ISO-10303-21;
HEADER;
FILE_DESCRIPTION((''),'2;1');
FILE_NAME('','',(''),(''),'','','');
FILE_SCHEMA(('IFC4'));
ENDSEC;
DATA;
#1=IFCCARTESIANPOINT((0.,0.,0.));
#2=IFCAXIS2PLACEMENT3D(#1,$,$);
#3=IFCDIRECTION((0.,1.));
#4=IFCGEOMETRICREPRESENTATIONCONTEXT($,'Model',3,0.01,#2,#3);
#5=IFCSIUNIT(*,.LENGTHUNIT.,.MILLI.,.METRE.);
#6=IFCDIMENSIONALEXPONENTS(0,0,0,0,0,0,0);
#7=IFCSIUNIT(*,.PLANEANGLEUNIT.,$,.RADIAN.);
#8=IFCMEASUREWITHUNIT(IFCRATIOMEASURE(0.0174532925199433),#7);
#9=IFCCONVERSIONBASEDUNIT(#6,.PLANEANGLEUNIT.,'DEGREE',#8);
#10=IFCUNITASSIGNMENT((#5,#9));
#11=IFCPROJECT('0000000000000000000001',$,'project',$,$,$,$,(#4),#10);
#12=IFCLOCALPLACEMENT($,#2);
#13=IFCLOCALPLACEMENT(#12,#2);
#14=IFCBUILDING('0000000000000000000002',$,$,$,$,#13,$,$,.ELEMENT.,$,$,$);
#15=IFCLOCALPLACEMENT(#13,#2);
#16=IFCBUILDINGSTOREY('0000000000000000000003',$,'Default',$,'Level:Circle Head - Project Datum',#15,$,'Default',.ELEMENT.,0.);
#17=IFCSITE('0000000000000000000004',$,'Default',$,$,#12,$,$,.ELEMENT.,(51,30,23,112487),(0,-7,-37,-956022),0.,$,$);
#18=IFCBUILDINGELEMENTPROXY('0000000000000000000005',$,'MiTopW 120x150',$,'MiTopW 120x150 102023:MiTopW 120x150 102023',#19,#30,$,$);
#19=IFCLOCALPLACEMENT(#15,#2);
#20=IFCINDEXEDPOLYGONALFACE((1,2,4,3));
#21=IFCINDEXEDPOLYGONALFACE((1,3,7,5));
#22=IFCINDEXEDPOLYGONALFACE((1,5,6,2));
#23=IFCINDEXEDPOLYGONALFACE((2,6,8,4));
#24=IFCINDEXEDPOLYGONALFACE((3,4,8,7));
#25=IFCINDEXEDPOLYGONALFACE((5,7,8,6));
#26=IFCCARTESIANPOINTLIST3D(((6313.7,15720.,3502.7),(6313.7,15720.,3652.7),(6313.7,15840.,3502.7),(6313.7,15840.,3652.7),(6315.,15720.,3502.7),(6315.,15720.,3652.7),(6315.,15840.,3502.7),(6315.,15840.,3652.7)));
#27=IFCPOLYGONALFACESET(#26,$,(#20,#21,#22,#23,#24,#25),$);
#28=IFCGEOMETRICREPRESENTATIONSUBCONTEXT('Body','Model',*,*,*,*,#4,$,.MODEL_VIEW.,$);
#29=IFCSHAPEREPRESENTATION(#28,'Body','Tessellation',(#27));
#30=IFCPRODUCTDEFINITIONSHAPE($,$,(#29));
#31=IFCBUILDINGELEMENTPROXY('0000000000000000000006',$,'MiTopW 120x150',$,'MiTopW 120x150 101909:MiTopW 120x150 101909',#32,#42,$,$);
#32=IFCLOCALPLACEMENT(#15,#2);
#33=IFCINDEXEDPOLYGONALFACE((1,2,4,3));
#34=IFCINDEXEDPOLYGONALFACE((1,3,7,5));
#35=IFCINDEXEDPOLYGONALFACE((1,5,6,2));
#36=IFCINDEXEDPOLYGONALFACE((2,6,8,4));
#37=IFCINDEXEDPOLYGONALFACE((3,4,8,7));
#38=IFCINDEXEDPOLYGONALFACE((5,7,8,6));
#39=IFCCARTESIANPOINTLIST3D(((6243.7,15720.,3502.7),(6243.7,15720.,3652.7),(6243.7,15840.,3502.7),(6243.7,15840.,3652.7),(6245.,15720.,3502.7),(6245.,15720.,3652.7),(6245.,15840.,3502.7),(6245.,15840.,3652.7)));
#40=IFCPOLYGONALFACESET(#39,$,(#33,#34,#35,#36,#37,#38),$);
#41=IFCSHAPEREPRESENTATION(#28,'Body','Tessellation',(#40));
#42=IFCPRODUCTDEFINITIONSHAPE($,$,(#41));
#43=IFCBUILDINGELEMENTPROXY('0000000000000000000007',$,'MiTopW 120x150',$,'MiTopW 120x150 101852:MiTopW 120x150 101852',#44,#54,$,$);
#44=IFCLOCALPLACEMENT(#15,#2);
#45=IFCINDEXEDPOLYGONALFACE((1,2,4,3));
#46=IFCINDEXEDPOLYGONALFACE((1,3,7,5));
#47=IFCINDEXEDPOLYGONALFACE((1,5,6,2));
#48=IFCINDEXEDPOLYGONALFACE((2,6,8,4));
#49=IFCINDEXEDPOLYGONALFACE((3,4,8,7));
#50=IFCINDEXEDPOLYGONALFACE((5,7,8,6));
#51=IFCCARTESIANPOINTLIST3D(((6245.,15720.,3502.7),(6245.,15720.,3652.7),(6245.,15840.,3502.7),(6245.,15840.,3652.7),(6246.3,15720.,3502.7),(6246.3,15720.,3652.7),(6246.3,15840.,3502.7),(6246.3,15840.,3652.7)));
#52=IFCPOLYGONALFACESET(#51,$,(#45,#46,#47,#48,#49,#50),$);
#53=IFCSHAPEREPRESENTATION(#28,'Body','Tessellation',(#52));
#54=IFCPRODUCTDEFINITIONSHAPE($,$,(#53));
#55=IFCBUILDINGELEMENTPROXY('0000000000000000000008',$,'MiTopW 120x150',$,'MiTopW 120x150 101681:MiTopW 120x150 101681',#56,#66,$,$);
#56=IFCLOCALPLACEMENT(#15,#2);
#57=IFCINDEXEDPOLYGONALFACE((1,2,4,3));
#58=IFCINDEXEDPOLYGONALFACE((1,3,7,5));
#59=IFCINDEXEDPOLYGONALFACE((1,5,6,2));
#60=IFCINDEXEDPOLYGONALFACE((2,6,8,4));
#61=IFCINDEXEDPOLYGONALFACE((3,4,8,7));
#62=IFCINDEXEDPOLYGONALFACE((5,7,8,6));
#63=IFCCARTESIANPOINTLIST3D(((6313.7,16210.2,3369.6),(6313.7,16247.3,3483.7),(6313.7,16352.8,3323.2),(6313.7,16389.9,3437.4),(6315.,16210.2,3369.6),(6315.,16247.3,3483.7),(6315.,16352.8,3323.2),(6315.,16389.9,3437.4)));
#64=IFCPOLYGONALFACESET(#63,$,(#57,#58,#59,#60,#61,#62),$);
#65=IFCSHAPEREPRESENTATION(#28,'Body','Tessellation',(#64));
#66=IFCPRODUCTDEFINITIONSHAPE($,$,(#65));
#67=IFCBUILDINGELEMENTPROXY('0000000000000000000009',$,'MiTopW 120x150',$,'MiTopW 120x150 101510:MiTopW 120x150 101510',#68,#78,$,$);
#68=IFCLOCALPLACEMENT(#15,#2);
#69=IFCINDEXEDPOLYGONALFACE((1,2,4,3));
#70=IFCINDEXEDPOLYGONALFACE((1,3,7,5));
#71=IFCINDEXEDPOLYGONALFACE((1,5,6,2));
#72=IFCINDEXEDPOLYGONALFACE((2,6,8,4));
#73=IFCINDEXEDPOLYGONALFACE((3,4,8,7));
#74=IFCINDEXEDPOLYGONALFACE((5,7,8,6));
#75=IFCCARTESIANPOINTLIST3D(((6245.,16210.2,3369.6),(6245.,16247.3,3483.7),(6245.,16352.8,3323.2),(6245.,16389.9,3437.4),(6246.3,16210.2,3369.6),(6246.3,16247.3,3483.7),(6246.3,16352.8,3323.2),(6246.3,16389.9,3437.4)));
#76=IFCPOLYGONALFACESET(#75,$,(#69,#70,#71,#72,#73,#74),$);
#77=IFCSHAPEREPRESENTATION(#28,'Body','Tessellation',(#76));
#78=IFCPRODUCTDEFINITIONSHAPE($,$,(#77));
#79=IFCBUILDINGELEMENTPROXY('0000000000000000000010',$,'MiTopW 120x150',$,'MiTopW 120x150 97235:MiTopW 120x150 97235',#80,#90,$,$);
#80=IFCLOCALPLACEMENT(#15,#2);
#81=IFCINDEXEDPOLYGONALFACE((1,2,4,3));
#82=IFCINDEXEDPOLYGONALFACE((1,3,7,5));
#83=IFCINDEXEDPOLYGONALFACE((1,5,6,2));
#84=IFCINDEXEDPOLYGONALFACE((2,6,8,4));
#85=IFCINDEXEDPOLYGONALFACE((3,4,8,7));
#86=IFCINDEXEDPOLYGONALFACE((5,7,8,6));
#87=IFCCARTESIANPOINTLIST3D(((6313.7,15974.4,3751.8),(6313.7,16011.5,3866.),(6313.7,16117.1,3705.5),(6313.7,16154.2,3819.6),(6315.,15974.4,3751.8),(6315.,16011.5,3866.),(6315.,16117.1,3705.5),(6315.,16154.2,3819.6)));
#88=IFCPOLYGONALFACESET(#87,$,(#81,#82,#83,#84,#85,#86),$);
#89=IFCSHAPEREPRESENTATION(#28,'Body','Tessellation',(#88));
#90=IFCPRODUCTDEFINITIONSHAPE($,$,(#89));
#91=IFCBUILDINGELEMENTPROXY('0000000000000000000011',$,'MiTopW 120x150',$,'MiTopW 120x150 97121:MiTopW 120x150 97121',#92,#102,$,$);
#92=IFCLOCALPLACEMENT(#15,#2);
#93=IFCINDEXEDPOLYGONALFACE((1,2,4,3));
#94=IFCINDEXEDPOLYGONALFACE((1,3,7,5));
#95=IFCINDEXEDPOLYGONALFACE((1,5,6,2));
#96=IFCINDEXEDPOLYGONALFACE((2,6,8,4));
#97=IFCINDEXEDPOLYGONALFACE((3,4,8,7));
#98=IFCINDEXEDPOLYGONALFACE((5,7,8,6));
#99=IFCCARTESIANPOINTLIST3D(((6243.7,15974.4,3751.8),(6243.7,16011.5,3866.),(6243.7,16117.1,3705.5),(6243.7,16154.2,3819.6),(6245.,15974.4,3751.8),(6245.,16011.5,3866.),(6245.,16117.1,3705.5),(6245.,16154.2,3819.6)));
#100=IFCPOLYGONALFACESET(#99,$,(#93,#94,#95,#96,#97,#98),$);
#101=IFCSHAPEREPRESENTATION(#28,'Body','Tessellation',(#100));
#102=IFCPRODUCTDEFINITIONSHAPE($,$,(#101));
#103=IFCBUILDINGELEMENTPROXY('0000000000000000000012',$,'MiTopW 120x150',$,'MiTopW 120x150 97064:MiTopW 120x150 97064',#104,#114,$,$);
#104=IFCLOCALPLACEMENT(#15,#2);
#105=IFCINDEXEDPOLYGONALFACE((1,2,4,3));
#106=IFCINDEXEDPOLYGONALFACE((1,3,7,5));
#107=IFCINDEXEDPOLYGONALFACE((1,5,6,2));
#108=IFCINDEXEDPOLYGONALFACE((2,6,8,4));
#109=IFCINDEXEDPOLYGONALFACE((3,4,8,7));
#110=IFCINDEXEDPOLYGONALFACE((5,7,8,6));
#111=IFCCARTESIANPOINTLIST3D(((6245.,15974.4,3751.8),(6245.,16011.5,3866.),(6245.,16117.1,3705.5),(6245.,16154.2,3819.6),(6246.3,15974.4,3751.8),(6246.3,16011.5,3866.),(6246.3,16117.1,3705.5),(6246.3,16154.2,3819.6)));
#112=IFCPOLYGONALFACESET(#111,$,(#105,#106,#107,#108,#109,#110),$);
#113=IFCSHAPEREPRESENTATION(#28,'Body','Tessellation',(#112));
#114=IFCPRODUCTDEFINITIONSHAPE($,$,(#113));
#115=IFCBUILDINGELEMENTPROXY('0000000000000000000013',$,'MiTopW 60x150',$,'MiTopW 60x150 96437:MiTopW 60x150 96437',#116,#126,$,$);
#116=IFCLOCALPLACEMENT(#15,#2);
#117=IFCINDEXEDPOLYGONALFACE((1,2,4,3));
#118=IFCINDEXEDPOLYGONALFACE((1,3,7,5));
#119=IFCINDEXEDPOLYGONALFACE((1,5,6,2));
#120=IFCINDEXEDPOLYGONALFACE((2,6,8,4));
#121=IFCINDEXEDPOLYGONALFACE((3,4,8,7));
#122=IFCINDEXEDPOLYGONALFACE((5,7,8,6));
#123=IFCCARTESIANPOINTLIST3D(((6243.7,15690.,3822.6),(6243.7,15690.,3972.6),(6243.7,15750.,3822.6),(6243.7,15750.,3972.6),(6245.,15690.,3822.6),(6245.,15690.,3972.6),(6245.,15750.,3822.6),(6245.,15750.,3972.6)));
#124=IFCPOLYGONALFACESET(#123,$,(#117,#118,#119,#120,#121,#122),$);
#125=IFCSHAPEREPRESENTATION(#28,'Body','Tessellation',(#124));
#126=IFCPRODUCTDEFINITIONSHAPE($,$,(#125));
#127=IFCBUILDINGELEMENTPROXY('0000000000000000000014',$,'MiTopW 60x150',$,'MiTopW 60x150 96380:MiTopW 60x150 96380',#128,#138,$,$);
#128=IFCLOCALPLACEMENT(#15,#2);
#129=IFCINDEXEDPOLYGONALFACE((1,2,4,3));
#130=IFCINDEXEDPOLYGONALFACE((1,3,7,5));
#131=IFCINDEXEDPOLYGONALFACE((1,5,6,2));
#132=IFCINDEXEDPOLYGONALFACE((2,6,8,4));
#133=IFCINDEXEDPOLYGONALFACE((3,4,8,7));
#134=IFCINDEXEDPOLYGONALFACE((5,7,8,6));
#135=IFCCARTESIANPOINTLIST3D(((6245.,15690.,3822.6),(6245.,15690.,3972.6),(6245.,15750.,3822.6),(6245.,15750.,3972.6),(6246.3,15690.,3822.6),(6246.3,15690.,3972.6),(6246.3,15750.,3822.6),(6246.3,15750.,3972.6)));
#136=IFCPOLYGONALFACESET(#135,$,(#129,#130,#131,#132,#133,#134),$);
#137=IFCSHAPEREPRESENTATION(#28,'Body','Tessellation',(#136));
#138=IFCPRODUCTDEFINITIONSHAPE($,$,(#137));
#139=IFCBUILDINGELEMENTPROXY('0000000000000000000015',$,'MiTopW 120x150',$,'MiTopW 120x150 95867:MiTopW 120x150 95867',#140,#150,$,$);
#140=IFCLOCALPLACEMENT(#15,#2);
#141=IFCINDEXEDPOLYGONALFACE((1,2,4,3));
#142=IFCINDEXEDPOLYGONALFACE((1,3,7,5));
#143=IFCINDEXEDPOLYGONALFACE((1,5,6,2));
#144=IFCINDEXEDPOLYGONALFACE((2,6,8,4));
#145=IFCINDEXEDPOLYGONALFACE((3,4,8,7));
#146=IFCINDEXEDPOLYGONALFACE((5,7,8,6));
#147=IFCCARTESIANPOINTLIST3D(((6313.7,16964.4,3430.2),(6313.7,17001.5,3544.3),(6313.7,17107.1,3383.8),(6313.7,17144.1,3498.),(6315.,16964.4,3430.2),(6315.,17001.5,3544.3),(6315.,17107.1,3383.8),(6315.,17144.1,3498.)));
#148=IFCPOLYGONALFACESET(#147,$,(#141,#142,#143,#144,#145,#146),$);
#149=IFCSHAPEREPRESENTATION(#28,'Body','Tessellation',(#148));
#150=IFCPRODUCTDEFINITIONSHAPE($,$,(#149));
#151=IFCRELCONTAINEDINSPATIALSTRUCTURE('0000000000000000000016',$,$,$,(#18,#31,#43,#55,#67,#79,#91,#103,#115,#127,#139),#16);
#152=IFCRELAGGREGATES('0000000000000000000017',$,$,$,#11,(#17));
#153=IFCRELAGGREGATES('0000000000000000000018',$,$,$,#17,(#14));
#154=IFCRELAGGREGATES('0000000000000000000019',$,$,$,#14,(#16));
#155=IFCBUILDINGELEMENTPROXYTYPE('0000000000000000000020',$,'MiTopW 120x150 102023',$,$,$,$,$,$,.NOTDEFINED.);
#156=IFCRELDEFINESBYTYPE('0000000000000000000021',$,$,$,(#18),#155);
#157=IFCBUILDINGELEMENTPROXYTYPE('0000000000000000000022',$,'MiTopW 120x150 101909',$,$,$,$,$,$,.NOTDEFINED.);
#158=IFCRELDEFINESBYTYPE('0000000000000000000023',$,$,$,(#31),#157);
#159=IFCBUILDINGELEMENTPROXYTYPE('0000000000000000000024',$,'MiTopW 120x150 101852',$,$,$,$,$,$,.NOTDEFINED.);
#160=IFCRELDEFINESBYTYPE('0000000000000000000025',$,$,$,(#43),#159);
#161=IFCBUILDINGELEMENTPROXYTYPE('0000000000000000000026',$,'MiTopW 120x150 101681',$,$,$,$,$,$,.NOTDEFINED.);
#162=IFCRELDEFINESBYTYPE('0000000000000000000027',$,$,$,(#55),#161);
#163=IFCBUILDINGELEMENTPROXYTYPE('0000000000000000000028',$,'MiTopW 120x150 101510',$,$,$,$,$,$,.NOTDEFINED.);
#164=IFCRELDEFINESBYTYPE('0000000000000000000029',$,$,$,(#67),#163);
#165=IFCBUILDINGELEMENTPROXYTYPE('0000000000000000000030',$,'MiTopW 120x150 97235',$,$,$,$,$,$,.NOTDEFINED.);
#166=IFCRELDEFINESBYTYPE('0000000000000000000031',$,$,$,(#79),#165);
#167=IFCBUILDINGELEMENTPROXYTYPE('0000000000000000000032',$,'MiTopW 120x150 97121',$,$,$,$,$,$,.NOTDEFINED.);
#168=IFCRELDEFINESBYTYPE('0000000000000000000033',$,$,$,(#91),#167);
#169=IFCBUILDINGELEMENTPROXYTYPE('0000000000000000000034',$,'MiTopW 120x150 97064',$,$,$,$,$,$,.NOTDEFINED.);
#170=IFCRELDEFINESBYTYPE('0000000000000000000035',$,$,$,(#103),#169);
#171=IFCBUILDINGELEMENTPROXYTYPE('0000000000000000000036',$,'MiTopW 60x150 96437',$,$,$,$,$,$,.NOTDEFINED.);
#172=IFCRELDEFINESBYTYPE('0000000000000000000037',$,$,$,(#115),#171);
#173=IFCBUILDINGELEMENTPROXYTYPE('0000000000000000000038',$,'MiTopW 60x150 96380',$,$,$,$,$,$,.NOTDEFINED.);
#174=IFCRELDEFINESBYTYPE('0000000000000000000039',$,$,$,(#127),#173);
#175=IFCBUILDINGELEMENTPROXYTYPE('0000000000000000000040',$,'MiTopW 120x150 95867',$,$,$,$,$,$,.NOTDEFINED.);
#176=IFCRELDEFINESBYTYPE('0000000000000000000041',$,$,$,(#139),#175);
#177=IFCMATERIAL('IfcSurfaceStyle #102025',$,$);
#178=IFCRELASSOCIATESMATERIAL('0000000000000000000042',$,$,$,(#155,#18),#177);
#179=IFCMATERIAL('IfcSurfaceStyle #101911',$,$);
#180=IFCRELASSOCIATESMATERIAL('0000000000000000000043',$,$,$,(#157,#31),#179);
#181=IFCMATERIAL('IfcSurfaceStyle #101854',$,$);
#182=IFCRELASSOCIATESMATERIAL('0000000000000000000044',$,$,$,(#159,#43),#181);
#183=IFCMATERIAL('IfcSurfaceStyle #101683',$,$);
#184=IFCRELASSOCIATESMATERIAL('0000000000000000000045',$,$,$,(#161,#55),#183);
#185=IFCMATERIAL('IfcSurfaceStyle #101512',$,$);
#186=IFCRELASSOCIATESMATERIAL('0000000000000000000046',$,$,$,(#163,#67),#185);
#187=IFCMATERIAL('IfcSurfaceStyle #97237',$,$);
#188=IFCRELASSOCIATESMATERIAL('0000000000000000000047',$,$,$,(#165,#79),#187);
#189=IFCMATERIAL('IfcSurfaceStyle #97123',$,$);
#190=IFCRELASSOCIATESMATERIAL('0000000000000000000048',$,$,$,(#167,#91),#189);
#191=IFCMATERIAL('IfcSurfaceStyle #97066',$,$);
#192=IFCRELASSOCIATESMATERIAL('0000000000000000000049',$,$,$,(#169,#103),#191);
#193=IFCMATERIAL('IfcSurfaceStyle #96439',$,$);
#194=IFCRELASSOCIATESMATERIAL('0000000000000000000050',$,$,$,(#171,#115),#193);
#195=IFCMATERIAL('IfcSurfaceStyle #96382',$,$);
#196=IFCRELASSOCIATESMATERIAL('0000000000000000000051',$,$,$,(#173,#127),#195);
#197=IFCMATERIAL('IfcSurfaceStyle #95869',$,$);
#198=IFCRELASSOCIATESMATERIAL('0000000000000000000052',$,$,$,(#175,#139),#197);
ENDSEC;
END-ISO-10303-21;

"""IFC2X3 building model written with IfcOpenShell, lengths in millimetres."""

from ifc_helpers import new_model, entity, si_unit, converted_unit, direction, frame, origin, origin_2d_with_axis, place, context, subcontext, project, spatial, polyline, rectangle, outline, extrude, source, transform, mapped, material, type_object, type_shapes, element, save


model = new_model("IFC2X3")

# Units and contexts
model_context = context("Model", 3, precision=0.01, world=origin(), true_north=direction((0.0, 1.0)))
body_context = subcontext(model_context, "Body", "Model", "MODEL_VIEW")
ifc_project = project(units=[si_unit("LENGTHUNIT", "METRE", prefix="MILLI"), converted_unit("PLANEANGLEUNIT", "DEGREE", entity("IfcRatioMeasure", 0.0174532925199433), si_unit("PLANEANGLEUNIT", "RADIAN"), dimensions=[0, 0, 0, 0, 0, 0, 0])], contexts=[model_context])

# Site, building, storey
site_placement = place(None, origin())
site = spatial("IfcSite", under=ifc_project, at=site_placement, Name="Default", CompositionType="ELEMENT", RefLatitude=(51, 30, 23, 112487), RefLongitude=(0, -7, -37, -956022), RefElevation=0.0)
building_placement = place(site_placement, origin())
building = spatial("IfcBuilding", under=site, at=building_placement, CompositionType="ELEMENT")
storey_placement = place(building_placement, origin())
storey = spatial("IfcBuildingStorey", under=building, at=storey_placement, Name="Default", ObjectType="Level:Circle Head - Project Datum", LongName="Default", CompositionType="ELEMENT", Elevation=0.0)

# Building element proxies
ifc_material_1 = material(Name="IfcSurfaceStyle #102025")
building_element_proxy_type_1 = type_object("IfcBuildingElementProxyType", Name="MiTopW 120x150 102023", PredefinedType="NOTDEFINED", material=ifc_material_1)
shared_shape_1 = source(origin(), body_context, "Body", "SweptSolid", [
    extrude(rectangle(XDim=150.0, YDim=120.0, at=origin_2d_with_axis()), frame((75.0, 60.0, 0.0), z_axis=(0.0, 0.0, 1.0), x_axis=(-1.0, 0.0, 0.0)), (0.0, 0.0, 1.0), 1.3),
])
type_shapes(building_element_proxy_type_1, [shared_shape_1])
proxy_1_placement = place(building_placement, frame((6315.0, 15840.0, 3652.7), z_axis=(-1.0, 0.0, 0.0), x_axis=(0.0, 0.0, -1.0)))
element("IfcBuildingElementProxy", 1, at=proxy_1_placement, inside=storey, type_object=building_element_proxy_type_1, material=ifc_material_1, Name="MiTopW 120x150", ObjectType="MiTopW 120x150 102023:MiTopW 120x150 102023", context=body_context, shape_type="MappedRepresentation", body=[
    mapped(shared_shape_1, transform((0.0, 0.0, 0.0), scale=1.0)),
])
ifc_material_2 = material(Name="IfcSurfaceStyle #101911")
building_element_proxy_type_2 = type_object("IfcBuildingElementProxyType", Name="MiTopW 120x150 101909", PredefinedType="NOTDEFINED", material=ifc_material_2)
shared_shape_2 = source(origin(), body_context, "Body", "SweptSolid", [
    extrude(rectangle(XDim=150.0, YDim=120.0, at=origin_2d_with_axis()), frame((75.0, 60.0, 0.0), z_axis=(0.0, 0.0, 1.0), x_axis=(-1.0, 0.0, 0.0)), (0.0, 0.0, 1.0), 1.3),
])
type_shapes(building_element_proxy_type_2, [shared_shape_2])
proxy_2_placement = place(building_placement, frame((6245.0, 15840.0, 3652.7), z_axis=(-1.0, 0.0, 0.0), x_axis=(0.0, 0.0, -1.0)))
element("IfcBuildingElementProxy", 2, at=proxy_2_placement, inside=storey, type_object=building_element_proxy_type_2, material=ifc_material_2, Name="MiTopW 120x150", ObjectType="MiTopW 120x150 101909:MiTopW 120x150 101909", context=body_context, shape_type="MappedRepresentation", body=[
    mapped(shared_shape_2, transform((0.0, 0.0, 0.0), scale=1.0)),
])
ifc_material_3 = material(Name="IfcSurfaceStyle #101854")
building_element_proxy_type_3 = type_object("IfcBuildingElementProxyType", Name="MiTopW 120x150 101852", PredefinedType="NOTDEFINED", material=ifc_material_3)
shared_shape_3 = source(origin(), body_context, "Body", "SweptSolid", [
    extrude(rectangle(XDim=150.0, YDim=120.0, at=origin_2d_with_axis()), frame((75.0, 60.0, 0.0), z_axis=(0.0, 0.0, 1.0), x_axis=(-1.0, 0.0, 0.0)), (0.0, 0.0, 1.0), 1.3),
])
type_shapes(building_element_proxy_type_3, [shared_shape_3])
proxy_3_placement = place(building_placement, frame((6246.3, 15840.0, 3652.7), z_axis=(-1.0, 0.0, 0.0), x_axis=(0.0, 0.0, -1.0)))
element("IfcBuildingElementProxy", 3, at=proxy_3_placement, inside=storey, type_object=building_element_proxy_type_3, material=ifc_material_3, Name="MiTopW 120x150", ObjectType="MiTopW 120x150 101852:MiTopW 120x150 101852", context=body_context, shape_type="MappedRepresentation", body=[
    mapped(shared_shape_3, transform((0.0, 0.0, 0.0), scale=1.0)),
])
ifc_material_4 = material(Name="IfcSurfaceStyle #101683")
building_element_proxy_type_4 = type_object("IfcBuildingElementProxyType", Name="MiTopW 120x150 101681", PredefinedType="NOTDEFINED", material=ifc_material_4)
shared_shape_4 = source(origin(), body_context, "Body", "SweptSolid", [
    extrude(outline(polyline([(-75.0, -60.0), (75.0, -60.0), (75.0, 60.0), (-75.0, 60.0), (-75.0, -60.0)])), frame((75.0, 60.0, 0.0), z_axis=(0.0, 0.0, 1.0), x_axis=(-1.0, 0.0, 0.0)), (0.0, 0.0, 1.0), 1.3),
])
type_shapes(building_element_proxy_type_4, [shared_shape_4])
proxy_4_placement = place(building_placement, frame((6315.0, 16352.8, 3323.2), z_axis=(-1.0, 0.0, 0.0), x_axis=(0.0, -0.951057, 0.309017)))
element("IfcBuildingElementProxy", 4, at=proxy_4_placement, inside=storey, type_object=building_element_proxy_type_4, material=ifc_material_4, Name="MiTopW 120x150", ObjectType="MiTopW 120x150 101681:MiTopW 120x150 101681", context=body_context, shape_type="MappedRepresentation", body=[
    mapped(shared_shape_4, transform((0.0, 0.0, 0.0), scale=1.0)),
])
ifc_material_5 = material(Name="IfcSurfaceStyle #101512")
building_element_proxy_type_5 = type_object("IfcBuildingElementProxyType", Name="MiTopW 120x150 101510", PredefinedType="NOTDEFINED", material=ifc_material_5)
shared_shape_5 = source(origin(), body_context, "Body", "SweptSolid", [
    extrude(outline(polyline([(-75.0, -60.0), (75.0, -60.0), (75.0, 60.0), (-75.0, 60.0), (-75.0, -60.0)])), frame((75.0, 60.0, 0.0), z_axis=(0.0, 0.0, 1.0), x_axis=(-1.0, 0.0, 0.0)), (0.0, 0.0, 1.0), 1.3),
])
type_shapes(building_element_proxy_type_5, [shared_shape_5])
proxy_5_placement = place(building_placement, frame((6246.3, 16352.8, 3323.2), z_axis=(-1.0, 0.0, 0.0), x_axis=(0.0, -0.951057, 0.309017)))
element("IfcBuildingElementProxy", 5, at=proxy_5_placement, inside=storey, type_object=building_element_proxy_type_5, material=ifc_material_5, Name="MiTopW 120x150", ObjectType="MiTopW 120x150 101510:MiTopW 120x150 101510", context=body_context, shape_type="MappedRepresentation", body=[
    mapped(shared_shape_5, transform((0.0, 0.0, 0.0), scale=1.0)),
])
ifc_material_6 = material(Name="IfcSurfaceStyle #97237")
building_element_proxy_type_6 = type_object("IfcBuildingElementProxyType", Name="MiTopW 120x150 97235", PredefinedType="NOTDEFINED", material=ifc_material_6)
shared_shape_6 = source(origin(), body_context, "Body", "SweptSolid", [
    extrude(outline(polyline([(-75.0, -60.0), (75.0, -60.0), (75.0, 60.0), (-75.0, 60.0), (-75.0, -60.0)])), frame((75.0, 60.0, 0.0), z_axis=(0.0, 0.0, 1.0), x_axis=(-1.0, 0.0, 0.0)), (0.0, 0.0, 1.0), 1.3),
])
type_shapes(building_element_proxy_type_6, [shared_shape_6])
proxy_6_placement = place(building_placement, frame((6315.0, 16117.1, 3705.5), z_axis=(-1.0, 0.0, 0.0), x_axis=(0.0, -0.951057, 0.309017)))
element("IfcBuildingElementProxy", 6, at=proxy_6_placement, inside=storey, type_object=building_element_proxy_type_6, material=ifc_material_6, Name="MiTopW 120x150", ObjectType="MiTopW 120x150 97235:MiTopW 120x150 97235", context=body_context, shape_type="MappedRepresentation", body=[
    mapped(shared_shape_6, transform((0.0, 0.0, 0.0), scale=1.0)),
])
ifc_material_7 = material(Name="IfcSurfaceStyle #97123")
building_element_proxy_type_7 = type_object("IfcBuildingElementProxyType", Name="MiTopW 120x150 97121", PredefinedType="NOTDEFINED", material=ifc_material_7)
shared_shape_7 = source(origin(), body_context, "Body", "SweptSolid", [
    extrude(outline(polyline([(-75.0, -60.0), (75.0, -60.0), (75.0, 60.0), (-75.0, 60.0), (-75.0, -60.0)])), frame((75.0, 60.0, 0.0), z_axis=(0.0, 0.0, 1.0), x_axis=(-1.0, 0.0, 0.0)), (0.0, 0.0, 1.0), 1.3),
])
type_shapes(building_element_proxy_type_7, [shared_shape_7])
proxy_7_placement = place(building_placement, frame((6245.0, 16117.1, 3705.5), z_axis=(-1.0, 0.0, 0.0), x_axis=(0.0, -0.951057, 0.309017)))
element("IfcBuildingElementProxy", 7, at=proxy_7_placement, inside=storey, type_object=building_element_proxy_type_7, material=ifc_material_7, Name="MiTopW 120x150", ObjectType="MiTopW 120x150 97121:MiTopW 120x150 97121", context=body_context, shape_type="MappedRepresentation", body=[
    mapped(shared_shape_7, transform((0.0, 0.0, 0.0), scale=1.0)),
])
ifc_material_8 = material(Name="IfcSurfaceStyle #97066")
building_element_proxy_type_8 = type_object("IfcBuildingElementProxyType", Name="MiTopW 120x150 97064", PredefinedType="NOTDEFINED", material=ifc_material_8)
shared_shape_8 = source(origin(), body_context, "Body", "SweptSolid", [
    extrude(outline(polyline([(-75.0, -60.0), (75.0, -60.0), (75.0, 60.0), (-75.0, 60.0), (-75.0, -60.0)])), frame((75.0, 60.0, 0.0), z_axis=(0.0, 0.0, 1.0), x_axis=(-1.0, 0.0, 0.0)), (0.0, 0.0, 1.0), 1.3),
])
type_shapes(building_element_proxy_type_8, [shared_shape_8])
proxy_8_placement = place(building_placement, frame((6246.3, 16117.1, 3705.5), z_axis=(-1.0, 0.0, 0.0), x_axis=(0.0, -0.951057, 0.309017)))
element("IfcBuildingElementProxy", 8, at=proxy_8_placement, inside=storey, type_object=building_element_proxy_type_8, material=ifc_material_8, Name="MiTopW 120x150", ObjectType="MiTopW 120x150 97064:MiTopW 120x150 97064", context=body_context, shape_type="MappedRepresentation", body=[
    mapped(shared_shape_8, transform((0.0, 0.0, 0.0), scale=1.0)),
])
ifc_material_9 = material(Name="IfcSurfaceStyle #96439")
building_element_proxy_type_9 = type_object("IfcBuildingElementProxyType", Name="MiTopW 60x150 96437", PredefinedType="NOTDEFINED", material=ifc_material_9)
shared_shape_9 = source(origin(), body_context, "Body", "SweptSolid", [
    extrude(rectangle(XDim=150.0, YDim=60.0, at=origin_2d_with_axis()), frame((75.0, 30.0, 0.0), z_axis=(0.0, 0.0, 1.0), x_axis=(-1.0, 0.0, 0.0)), (0.0, 0.0, 1.0), 1.3),
])
type_shapes(building_element_proxy_type_9, [shared_shape_9])
proxy_9_placement = place(building_placement, frame((6245.0, 15750.0, 3972.6), z_axis=(-1.0, 0.0, 0.0), x_axis=(0.0, 0.0, -1.0)))
element("IfcBuildingElementProxy", 9, at=proxy_9_placement, inside=storey, type_object=building_element_proxy_type_9, material=ifc_material_9, Name="MiTopW 60x150", ObjectType="MiTopW 60x150 96437:MiTopW 60x150 96437", context=body_context, shape_type="MappedRepresentation", body=[
    mapped(shared_shape_9, transform((0.0, 0.0, 0.0), scale=1.0)),
])
ifc_material_10 = material(Name="IfcSurfaceStyle #96382")
building_element_proxy_type_10 = type_object("IfcBuildingElementProxyType", Name="MiTopW 60x150 96380", PredefinedType="NOTDEFINED", material=ifc_material_10)
shared_shape_10 = source(origin(), body_context, "Body", "SweptSolid", [
    extrude(rectangle(XDim=150.0, YDim=60.0, at=origin_2d_with_axis()), frame((75.0, 30.0, 0.0), z_axis=(0.0, 0.0, 1.0), x_axis=(-1.0, 0.0, 0.0)), (0.0, 0.0, 1.0), 1.3),
])
type_shapes(building_element_proxy_type_10, [shared_shape_10])
proxy_10_placement = place(building_placement, frame((6246.3, 15750.0, 3972.6), z_axis=(-1.0, 0.0, 0.0), x_axis=(0.0, 0.0, -1.0)))
element("IfcBuildingElementProxy", 10, at=proxy_10_placement, inside=storey, type_object=building_element_proxy_type_10, material=ifc_material_10, Name="MiTopW 60x150", ObjectType="MiTopW 60x150 96380:MiTopW 60x150 96380", context=body_context, shape_type="MappedRepresentation", body=[
    mapped(shared_shape_10, transform((0.0, 0.0, 0.0), scale=1.0)),
])
ifc_material_11 = material(Name="IfcSurfaceStyle #95869")
building_element_proxy_type_11 = type_object("IfcBuildingElementProxyType", Name="MiTopW 120x150 95867", PredefinedType="NOTDEFINED", material=ifc_material_11)
shared_shape_11 = source(origin(), body_context, "Body", "SweptSolid", [
    extrude(outline(polyline([(-75.0, -60.0), (75.0, -60.0), (75.0, 60.0), (-75.0, 60.0), (-75.0, -60.0)])), frame((75.0, 60.0, 0.0), z_axis=(0.0, 0.0, 1.0), x_axis=(-1.0, 0.0, 0.0)), (0.0, 0.0, 1.0), 1.3),
])
type_shapes(building_element_proxy_type_11, [shared_shape_11])
proxy_11_placement = place(building_placement, frame((6315.0, 17107.1, 3383.8), z_axis=(-1.0, 0.0, 0.0), x_axis=(0.0, -0.951057, 0.309017)))
element("IfcBuildingElementProxy", 11, at=proxy_11_placement, inside=storey, type_object=building_element_proxy_type_11, material=ifc_material_11, Name="MiTopW 120x150", ObjectType="MiTopW 120x150 95867:MiTopW 120x150 95867", context=body_context, shape_type="MappedRepresentation", body=[
    mapped(shared_shape_11, transform((0.0, 0.0, 0.0), scale=1.0)),
])

save(model, "model.ifc")
